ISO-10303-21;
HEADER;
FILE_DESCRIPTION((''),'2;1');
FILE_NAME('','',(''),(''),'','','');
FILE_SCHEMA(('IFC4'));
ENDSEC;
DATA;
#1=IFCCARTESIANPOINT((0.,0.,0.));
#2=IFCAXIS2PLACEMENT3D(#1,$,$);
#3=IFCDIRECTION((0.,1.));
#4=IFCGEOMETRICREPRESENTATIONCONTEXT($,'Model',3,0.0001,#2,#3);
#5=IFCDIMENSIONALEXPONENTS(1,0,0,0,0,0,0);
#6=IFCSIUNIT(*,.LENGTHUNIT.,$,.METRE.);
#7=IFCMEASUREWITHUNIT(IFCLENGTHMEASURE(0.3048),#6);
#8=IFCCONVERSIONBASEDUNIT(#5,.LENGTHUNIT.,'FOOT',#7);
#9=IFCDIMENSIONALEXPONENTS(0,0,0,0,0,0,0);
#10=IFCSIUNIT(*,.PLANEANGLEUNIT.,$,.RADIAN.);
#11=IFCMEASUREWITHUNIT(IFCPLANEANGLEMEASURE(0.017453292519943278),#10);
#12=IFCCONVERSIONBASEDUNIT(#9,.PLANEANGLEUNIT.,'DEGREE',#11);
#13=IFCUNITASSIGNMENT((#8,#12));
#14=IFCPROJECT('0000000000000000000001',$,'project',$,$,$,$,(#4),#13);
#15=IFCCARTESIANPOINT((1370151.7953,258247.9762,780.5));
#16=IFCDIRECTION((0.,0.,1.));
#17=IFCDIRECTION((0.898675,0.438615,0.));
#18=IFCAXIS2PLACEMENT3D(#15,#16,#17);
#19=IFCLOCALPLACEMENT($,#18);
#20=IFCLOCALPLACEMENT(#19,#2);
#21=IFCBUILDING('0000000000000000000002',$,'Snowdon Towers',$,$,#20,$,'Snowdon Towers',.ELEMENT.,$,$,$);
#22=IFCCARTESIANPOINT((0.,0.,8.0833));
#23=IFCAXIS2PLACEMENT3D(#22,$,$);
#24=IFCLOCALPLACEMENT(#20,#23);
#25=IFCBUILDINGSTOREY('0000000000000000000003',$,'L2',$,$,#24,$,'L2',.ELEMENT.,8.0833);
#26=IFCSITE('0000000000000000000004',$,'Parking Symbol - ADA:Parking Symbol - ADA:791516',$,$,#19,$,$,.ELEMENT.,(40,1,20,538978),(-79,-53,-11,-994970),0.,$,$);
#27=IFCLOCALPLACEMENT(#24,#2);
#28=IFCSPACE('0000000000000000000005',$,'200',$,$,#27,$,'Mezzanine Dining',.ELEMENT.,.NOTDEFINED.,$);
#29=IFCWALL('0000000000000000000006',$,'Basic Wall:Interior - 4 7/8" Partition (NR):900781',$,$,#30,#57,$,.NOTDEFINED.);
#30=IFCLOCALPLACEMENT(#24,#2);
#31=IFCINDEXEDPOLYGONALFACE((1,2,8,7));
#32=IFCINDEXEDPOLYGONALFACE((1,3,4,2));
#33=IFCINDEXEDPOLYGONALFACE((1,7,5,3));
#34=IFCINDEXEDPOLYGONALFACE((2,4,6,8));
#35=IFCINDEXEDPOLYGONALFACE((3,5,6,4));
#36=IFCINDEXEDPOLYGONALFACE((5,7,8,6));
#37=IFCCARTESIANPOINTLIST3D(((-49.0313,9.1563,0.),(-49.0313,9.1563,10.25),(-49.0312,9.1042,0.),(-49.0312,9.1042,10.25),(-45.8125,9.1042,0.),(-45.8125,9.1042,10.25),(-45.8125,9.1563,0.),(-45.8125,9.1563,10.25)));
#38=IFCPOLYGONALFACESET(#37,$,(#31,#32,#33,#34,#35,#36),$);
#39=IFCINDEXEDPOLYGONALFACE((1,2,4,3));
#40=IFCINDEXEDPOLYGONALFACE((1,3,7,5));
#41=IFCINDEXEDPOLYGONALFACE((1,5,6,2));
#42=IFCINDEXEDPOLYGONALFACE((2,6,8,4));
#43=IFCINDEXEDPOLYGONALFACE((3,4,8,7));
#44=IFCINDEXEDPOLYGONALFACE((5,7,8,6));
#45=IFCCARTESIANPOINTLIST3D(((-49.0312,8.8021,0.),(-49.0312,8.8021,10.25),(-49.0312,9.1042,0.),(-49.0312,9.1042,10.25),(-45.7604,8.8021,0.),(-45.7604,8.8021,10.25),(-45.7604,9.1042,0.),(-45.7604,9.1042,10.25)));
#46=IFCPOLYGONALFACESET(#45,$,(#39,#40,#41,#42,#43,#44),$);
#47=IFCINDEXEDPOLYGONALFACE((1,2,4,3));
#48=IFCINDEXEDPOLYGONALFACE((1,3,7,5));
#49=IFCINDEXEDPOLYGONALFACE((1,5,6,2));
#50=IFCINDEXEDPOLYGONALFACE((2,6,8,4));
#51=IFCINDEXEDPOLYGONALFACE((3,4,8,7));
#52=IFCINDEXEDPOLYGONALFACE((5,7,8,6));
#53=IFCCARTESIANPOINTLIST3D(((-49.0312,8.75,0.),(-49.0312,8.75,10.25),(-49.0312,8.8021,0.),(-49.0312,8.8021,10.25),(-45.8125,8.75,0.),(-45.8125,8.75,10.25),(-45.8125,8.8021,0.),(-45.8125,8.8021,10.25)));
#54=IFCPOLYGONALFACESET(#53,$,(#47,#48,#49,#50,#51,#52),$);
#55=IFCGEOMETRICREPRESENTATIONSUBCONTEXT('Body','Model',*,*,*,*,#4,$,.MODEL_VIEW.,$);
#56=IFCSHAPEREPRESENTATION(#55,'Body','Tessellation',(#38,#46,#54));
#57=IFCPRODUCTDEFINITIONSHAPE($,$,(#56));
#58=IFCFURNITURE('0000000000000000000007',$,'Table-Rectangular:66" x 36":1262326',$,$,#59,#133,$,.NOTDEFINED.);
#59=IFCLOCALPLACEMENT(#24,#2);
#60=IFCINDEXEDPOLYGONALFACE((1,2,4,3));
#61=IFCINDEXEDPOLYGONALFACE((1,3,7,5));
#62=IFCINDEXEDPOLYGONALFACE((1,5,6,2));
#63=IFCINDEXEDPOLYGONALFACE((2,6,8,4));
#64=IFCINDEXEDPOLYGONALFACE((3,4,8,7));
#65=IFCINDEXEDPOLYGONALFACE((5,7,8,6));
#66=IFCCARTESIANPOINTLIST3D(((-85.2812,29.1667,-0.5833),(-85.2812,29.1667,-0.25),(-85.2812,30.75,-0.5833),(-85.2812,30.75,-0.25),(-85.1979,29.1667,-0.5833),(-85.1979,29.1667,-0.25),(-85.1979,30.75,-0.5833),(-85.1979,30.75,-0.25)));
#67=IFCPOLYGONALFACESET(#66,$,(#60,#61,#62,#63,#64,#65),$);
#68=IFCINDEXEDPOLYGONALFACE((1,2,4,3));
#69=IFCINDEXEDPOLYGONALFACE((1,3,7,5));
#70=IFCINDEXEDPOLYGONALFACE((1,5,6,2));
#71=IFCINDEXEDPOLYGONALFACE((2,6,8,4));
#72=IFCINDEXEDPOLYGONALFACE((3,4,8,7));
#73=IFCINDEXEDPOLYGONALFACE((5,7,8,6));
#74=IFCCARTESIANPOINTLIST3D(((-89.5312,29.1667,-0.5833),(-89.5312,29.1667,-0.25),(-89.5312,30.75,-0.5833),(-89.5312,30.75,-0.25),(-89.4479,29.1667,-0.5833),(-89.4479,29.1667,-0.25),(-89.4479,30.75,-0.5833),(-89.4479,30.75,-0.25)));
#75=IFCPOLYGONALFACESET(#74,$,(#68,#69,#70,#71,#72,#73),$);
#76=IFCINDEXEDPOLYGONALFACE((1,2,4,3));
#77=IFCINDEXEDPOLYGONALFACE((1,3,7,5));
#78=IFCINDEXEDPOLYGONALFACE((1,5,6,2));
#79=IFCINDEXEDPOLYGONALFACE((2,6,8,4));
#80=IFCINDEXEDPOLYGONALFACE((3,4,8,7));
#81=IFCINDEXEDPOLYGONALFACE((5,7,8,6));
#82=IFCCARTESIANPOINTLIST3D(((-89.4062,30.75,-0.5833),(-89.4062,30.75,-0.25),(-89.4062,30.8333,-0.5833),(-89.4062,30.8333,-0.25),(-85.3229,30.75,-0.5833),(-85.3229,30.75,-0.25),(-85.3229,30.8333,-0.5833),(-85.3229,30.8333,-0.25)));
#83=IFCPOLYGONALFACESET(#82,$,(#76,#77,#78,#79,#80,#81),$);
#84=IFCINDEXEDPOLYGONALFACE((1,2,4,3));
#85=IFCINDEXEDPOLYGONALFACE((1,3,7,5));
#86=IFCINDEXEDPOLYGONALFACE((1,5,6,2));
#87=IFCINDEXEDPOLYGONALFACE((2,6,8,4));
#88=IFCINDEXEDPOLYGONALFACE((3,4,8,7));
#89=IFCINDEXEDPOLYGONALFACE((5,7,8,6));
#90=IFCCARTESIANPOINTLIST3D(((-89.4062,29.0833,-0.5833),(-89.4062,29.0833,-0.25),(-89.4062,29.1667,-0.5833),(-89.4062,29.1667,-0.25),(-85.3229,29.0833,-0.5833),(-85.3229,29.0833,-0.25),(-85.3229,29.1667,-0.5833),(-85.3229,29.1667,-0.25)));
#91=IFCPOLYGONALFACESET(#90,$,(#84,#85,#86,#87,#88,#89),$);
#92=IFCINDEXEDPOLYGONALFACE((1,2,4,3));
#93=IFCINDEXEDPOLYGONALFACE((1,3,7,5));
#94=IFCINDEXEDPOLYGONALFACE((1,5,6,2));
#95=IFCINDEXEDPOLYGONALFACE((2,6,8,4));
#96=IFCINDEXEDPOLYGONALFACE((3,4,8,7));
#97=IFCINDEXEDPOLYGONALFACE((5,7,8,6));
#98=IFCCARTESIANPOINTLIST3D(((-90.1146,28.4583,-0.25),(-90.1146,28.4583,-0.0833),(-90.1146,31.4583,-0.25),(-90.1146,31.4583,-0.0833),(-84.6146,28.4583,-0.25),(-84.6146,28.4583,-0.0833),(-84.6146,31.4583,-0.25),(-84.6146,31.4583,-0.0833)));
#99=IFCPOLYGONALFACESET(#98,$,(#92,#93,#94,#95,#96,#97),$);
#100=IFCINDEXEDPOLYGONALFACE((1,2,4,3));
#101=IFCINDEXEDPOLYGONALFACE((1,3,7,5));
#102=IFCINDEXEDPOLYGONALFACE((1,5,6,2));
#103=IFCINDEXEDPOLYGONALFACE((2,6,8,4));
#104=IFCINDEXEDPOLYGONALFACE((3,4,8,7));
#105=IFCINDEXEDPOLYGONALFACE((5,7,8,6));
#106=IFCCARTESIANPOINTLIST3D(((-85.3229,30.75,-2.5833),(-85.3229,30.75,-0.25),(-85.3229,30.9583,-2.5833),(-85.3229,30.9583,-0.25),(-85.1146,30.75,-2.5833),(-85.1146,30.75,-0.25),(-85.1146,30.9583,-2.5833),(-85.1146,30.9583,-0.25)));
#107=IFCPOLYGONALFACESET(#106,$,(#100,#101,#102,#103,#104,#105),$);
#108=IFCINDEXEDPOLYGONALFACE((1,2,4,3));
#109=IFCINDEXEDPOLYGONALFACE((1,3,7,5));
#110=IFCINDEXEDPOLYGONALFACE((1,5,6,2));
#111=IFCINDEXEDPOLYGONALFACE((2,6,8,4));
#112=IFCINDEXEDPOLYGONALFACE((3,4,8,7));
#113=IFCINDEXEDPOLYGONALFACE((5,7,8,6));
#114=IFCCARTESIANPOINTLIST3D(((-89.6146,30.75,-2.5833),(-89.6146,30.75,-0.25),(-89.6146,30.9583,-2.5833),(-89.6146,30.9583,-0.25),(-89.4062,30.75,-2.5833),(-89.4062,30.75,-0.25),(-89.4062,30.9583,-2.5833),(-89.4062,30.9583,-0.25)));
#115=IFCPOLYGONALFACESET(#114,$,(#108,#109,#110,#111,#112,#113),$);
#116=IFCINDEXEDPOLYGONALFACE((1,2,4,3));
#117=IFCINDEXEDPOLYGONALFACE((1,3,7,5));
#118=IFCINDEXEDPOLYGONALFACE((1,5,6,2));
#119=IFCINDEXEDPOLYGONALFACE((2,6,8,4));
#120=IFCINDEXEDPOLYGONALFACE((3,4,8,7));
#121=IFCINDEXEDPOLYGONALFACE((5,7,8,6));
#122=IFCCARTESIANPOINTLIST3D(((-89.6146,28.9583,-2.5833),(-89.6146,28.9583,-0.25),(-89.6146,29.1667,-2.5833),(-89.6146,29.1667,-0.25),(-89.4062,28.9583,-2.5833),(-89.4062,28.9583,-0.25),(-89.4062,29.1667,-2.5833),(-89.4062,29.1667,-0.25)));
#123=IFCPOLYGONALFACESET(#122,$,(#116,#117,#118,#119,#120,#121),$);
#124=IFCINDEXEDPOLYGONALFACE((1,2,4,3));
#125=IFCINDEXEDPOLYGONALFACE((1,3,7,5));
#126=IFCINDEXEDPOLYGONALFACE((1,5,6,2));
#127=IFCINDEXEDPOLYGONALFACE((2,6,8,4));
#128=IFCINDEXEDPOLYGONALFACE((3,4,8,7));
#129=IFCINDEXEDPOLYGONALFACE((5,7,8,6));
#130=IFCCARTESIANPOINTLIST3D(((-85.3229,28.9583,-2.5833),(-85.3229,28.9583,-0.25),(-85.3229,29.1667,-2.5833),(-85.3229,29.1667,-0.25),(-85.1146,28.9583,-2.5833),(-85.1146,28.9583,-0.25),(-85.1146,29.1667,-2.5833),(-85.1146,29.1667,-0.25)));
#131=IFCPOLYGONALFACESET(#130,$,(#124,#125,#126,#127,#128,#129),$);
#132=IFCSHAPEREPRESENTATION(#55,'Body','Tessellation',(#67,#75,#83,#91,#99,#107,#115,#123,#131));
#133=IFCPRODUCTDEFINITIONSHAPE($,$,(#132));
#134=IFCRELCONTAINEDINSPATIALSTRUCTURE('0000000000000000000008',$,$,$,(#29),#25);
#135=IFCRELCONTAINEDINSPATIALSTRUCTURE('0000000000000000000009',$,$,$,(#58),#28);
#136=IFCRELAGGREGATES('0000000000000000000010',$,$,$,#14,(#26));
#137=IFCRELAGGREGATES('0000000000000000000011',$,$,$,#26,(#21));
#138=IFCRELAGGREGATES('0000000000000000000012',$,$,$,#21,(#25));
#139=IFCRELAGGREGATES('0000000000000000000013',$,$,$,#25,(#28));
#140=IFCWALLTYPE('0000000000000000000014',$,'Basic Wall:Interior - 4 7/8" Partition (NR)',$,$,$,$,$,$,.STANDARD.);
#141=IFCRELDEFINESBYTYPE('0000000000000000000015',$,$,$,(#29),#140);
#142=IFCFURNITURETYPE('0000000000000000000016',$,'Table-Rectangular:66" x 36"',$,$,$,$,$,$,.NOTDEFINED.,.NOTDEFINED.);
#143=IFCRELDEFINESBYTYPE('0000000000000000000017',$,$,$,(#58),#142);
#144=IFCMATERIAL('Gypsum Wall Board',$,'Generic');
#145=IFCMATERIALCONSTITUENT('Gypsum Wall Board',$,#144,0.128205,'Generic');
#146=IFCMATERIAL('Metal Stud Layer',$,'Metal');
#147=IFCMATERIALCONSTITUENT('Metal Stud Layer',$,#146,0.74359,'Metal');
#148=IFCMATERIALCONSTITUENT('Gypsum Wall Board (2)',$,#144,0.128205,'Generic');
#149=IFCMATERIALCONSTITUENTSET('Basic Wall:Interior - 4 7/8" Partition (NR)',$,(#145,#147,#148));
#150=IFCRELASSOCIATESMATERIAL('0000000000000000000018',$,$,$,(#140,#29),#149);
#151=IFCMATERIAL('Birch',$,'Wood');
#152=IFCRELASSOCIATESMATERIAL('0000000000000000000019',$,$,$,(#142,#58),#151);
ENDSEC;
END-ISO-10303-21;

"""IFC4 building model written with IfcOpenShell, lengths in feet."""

from ifc_helpers import new_model, entity, si_unit, converted_unit, direction, frame, origin, place, context, subcontext, project, spatial, indexed_curve, outline, extrude, source, transform, mapped, material, constituent, constituent_set, type_object, type_shapes, element, save


model = new_model("IFC4")

# Units and contexts
model_context = context("Model", 3, precision=0.0001, world=origin(), true_north=direction((0.0, 1.0)))
body_context = subcontext(model_context, "Body", "Model", "MODEL_VIEW")
ifc_project = project(units=[converted_unit("LENGTHUNIT", "FOOT", entity("IfcLengthMeasure", 0.3048), si_unit("LENGTHUNIT", "METRE"), dimensions=[1, 0, 0, 0, 0, 0, 0]), converted_unit("PLANEANGLEUNIT", "DEGREE", entity("IfcPlaneAngleMeasure", 0.017453292519943278), si_unit("PLANEANGLEUNIT", "RADIAN"), dimensions=[0, 0, 0, 0, 0, 0, 0])], contexts=[model_context])

# Site, building, storey
site_placement = place(None, frame((1370151.7953, 258247.9762, 780.5), z_axis=(0.0, 0.0, 1.0), x_axis=(0.898675, 0.438615, 0.0)))
site = spatial("IfcSite", under=ifc_project, at=site_placement, Name="Parking Symbol - ADA:Parking Symbol - ADA:791516", CompositionType="ELEMENT", RefLatitude=(40, 1, 20, 538978), RefLongitude=(-79, -53, -11, -994970), RefElevation=0.0)
building_placement = place(site_placement, origin())
building = spatial("IfcBuilding", under=site, at=building_placement, Name="Snowdon Towers", LongName="Snowdon Towers", CompositionType="ELEMENT")
storey_placement = place(building_placement, frame((0.0, 0.0, 8.0833)))
storey = spatial("IfcBuildingStorey", under=building, at=storey_placement, Name="L2", LongName="L2", CompositionType="ELEMENT", Elevation=8.0833)

# Wall
ifc_material_1 = material(Name="Gypsum Wall Board", Category="Generic")
ifc_constituent_1 = constituent(ifc_material_1, Name="Gypsum Wall Board", Category="Generic", fraction=0.128205)
ifc_material_2 = material(Name="Metal Stud Layer", Category="Metal")
ifc_constituent_2 = constituent(ifc_material_2, Name="Metal Stud Layer", Category="Metal", fraction=0.74359)
ifc_constituent_3 = constituent(ifc_material_1, Name="Gypsum Wall Board (2)", Category="Generic", fraction=0.128205)
ifc_constituent_set_1 = constituent_set(constituents=[ifc_constituent_1, ifc_constituent_2, ifc_constituent_3], Name="Basic Wall:Interior - 4 7/8\" Partition (NR)")
wall_type_1 = type_object("IfcWallType", Name="Basic Wall:Interior - 4 7/8\" Partition (NR)", PredefinedType="STANDARD", material=ifc_constituent_set_1)
wall_1_placement = place(storey_placement, frame((-45.8125, 8.9531, 0.0), z_axis=(0.0, 0.0, 1.0), x_axis=(-1.0, 0.0, 0.0)))
element("IfcWall", 1, at=wall_1_placement, inside=storey, type_object=wall_type_1, material=ifc_constituent_set_1, Name="Basic Wall:Interior - 4 7/8\" Partition (NR):900781", PredefinedType="NOTDEFINED", context=body_context, shape_type="SweptSolid", body=[
    extrude(outline(indexed_curve([(-0.026, -1.6094), (0.026, -1.6094), (0.026, 1.6094), (-0.026, 1.6094), (-0.026, -1.6094)], self_intersect=False)), frame((1.6094, -0.1771, 0.0), z_axis=(0.0, 0.0, 1.0), x_axis=(0.0, 1.0, 0.0)), (0.0, 0.0, 1.0), 10.25),
    extrude(outline(indexed_curve([(-1.6354, -0.151), (1.6354, -0.151), (1.6354, 0.151), (-1.6354, 0.151), (-1.6354, -0.151)], self_intersect=False)), frame((1.5833, 0.0, 0.0)), (0.0, 0.0, 1.0), 10.25),
    extrude(outline(indexed_curve([(-0.026, -1.6094), (0.026, -1.6094), (0.026, 1.6094), (-0.026, 1.6094), (-0.026, -1.6094)], self_intersect=False)), frame((1.6094, 0.1771, 0.0), z_axis=(0.0, 0.0, 1.0), x_axis=(0.0, -1.0, 0.0)), (0.0, 0.0, 1.0), 10.25),
])

# Shared definitions
space_1_placement = place(storey_placement, origin())
space_1 = spatial("IfcSpace", under=storey, at=space_1_placement, Name="200", LongName="Mezzanine Dining", CompositionType="ELEMENT", PredefinedType="NOTDEFINED")

# Furniture
ifc_material_3 = material(Name="Birch", Category="Wood")
furniture_type_1 = type_object("IfcFurnitureType", Name="Table-Rectangular:66\" x 36\"", AssemblyPlace="NOTDEFINED", PredefinedType="NOTDEFINED", material=ifc_material_3)
shared_shape_1 = source(origin(), body_context, "Body", "SweptSolid", [
    extrude(outline(indexed_curve([(-0.0417, -0.7917), (0.0417, -0.7917), (0.0417, 0.7917), (-0.0417, 0.7917), (-0.0417, -0.7917)], self_intersect=False)), frame((2.125, 0.0, 2.0)), (0.0, 0.0, 1.0), 0.3333),
    extrude(outline(indexed_curve([(-0.7917, -0.0417), (0.7917, -0.0417), (0.7917, 0.0417), (-0.7917, 0.0417), (-0.7917, -0.0417)], self_intersect=False)), frame((-2.125, 0.0, 2.0), z_axis=(0.0, 0.0, 1.0), x_axis=(0.0, 1.0, 0.0)), (0.0, 0.0, 1.0), 0.3333),
    extrude(outline(indexed_curve([(-2.0417, -0.0417), (2.0417, -0.0417), (2.0417, 0.0417), (-2.0417, 0.0417), (-2.0417, -0.0417)], self_intersect=False)), frame((0.0, 0.8333, 2.0), z_axis=(0.0, 0.0, 1.0), x_axis=(-1.0, 0.0, 0.0)), (0.0, 0.0, 1.0), 0.3333),
    extrude(outline(indexed_curve([(-0.0417, -2.0417), (0.0417, -2.0417), (0.0417, 2.0417), (-0.0417, 2.0417), (-0.0417, -2.0417)], self_intersect=False)), frame((0.0, -0.8333, 2.0), z_axis=(0.0, 0.0, 1.0), x_axis=(0.0, 1.0, 0.0)), (0.0, 0.0, 1.0), 0.3333),
    extrude(outline(indexed_curve([(-2.75, -1.5), (2.75, -1.5), (2.75, 1.5), (-2.75, 1.5), (-2.75, -1.5)], self_intersect=False)), frame((0.0, 0.0, 2.3333), z_axis=(0.0, 0.0, 1.0), x_axis=(-1.0, 0.0, 0.0)), (0.0, 0.0, 1.0), 0.1667),
    extrude(outline(indexed_curve([(-0.1042, -0.1042), (0.1042, -0.1042), (0.1042, 0.1042), (-0.1042, 0.1042), (-0.1042, -0.1042)], self_intersect=False)), frame((2.1458, 0.8958, 0.0), z_axis=(0.0, 0.0, 1.0), x_axis=(0.0, -1.0, 0.0)), (0.0, 0.0, 1.0), 2.3333),
    extrude(outline(indexed_curve([(-0.1042, -0.1042), (0.1042, -0.1042), (0.1042, 0.1042), (-0.1042, 0.1042), (-0.1042, -0.1042)], self_intersect=False)), frame((-2.1458, 0.8958, 0.0), z_axis=(0.0, 0.0, 1.0), x_axis=(-1.0, 0.0, 0.0)), (0.0, 0.0, 1.0), 2.3333),
    extrude(outline(indexed_curve([(-0.1042, -0.1042), (0.1042, -0.1042), (0.1042, 0.1042), (-0.1042, 0.1042), (-0.1042, -0.1042)], self_intersect=False)), frame((-2.1458, -0.8958, 0.0), z_axis=(0.0, 0.0, 1.0), x_axis=(0.0, 1.0, 0.0)), (0.0, 0.0, 1.0), 2.3333),
    extrude(outline(indexed_curve([(-0.1042, -0.1042), (0.1042, -0.1042), (0.1042, 0.1042), (-0.1042, 0.1042), (-0.1042, -0.1042)], self_intersect=False)), frame((2.1458, -0.8958, 0.0)), (0.0, 0.0, 1.0), 2.3333),
])
type_shapes(furniture_type_1, [shared_shape_1])
furniture_1_placement = place(space_1_placement, frame((-87.3646, 29.9583, -2.5833)))
element("IfcFurniture", 2, at=furniture_1_placement, inside=space_1, type_object=furniture_type_1, material=ifc_material_3, Name="Table-Rectangular:66\" x 36\":1262326", PredefinedType="NOTDEFINED", context=body_context, shape_type="MappedRepresentation", body=[
    mapped(shared_shape_1, transform((0.0, 0.0, 0.0), scale=1.0)),
])

save(model, "model.ifc")
